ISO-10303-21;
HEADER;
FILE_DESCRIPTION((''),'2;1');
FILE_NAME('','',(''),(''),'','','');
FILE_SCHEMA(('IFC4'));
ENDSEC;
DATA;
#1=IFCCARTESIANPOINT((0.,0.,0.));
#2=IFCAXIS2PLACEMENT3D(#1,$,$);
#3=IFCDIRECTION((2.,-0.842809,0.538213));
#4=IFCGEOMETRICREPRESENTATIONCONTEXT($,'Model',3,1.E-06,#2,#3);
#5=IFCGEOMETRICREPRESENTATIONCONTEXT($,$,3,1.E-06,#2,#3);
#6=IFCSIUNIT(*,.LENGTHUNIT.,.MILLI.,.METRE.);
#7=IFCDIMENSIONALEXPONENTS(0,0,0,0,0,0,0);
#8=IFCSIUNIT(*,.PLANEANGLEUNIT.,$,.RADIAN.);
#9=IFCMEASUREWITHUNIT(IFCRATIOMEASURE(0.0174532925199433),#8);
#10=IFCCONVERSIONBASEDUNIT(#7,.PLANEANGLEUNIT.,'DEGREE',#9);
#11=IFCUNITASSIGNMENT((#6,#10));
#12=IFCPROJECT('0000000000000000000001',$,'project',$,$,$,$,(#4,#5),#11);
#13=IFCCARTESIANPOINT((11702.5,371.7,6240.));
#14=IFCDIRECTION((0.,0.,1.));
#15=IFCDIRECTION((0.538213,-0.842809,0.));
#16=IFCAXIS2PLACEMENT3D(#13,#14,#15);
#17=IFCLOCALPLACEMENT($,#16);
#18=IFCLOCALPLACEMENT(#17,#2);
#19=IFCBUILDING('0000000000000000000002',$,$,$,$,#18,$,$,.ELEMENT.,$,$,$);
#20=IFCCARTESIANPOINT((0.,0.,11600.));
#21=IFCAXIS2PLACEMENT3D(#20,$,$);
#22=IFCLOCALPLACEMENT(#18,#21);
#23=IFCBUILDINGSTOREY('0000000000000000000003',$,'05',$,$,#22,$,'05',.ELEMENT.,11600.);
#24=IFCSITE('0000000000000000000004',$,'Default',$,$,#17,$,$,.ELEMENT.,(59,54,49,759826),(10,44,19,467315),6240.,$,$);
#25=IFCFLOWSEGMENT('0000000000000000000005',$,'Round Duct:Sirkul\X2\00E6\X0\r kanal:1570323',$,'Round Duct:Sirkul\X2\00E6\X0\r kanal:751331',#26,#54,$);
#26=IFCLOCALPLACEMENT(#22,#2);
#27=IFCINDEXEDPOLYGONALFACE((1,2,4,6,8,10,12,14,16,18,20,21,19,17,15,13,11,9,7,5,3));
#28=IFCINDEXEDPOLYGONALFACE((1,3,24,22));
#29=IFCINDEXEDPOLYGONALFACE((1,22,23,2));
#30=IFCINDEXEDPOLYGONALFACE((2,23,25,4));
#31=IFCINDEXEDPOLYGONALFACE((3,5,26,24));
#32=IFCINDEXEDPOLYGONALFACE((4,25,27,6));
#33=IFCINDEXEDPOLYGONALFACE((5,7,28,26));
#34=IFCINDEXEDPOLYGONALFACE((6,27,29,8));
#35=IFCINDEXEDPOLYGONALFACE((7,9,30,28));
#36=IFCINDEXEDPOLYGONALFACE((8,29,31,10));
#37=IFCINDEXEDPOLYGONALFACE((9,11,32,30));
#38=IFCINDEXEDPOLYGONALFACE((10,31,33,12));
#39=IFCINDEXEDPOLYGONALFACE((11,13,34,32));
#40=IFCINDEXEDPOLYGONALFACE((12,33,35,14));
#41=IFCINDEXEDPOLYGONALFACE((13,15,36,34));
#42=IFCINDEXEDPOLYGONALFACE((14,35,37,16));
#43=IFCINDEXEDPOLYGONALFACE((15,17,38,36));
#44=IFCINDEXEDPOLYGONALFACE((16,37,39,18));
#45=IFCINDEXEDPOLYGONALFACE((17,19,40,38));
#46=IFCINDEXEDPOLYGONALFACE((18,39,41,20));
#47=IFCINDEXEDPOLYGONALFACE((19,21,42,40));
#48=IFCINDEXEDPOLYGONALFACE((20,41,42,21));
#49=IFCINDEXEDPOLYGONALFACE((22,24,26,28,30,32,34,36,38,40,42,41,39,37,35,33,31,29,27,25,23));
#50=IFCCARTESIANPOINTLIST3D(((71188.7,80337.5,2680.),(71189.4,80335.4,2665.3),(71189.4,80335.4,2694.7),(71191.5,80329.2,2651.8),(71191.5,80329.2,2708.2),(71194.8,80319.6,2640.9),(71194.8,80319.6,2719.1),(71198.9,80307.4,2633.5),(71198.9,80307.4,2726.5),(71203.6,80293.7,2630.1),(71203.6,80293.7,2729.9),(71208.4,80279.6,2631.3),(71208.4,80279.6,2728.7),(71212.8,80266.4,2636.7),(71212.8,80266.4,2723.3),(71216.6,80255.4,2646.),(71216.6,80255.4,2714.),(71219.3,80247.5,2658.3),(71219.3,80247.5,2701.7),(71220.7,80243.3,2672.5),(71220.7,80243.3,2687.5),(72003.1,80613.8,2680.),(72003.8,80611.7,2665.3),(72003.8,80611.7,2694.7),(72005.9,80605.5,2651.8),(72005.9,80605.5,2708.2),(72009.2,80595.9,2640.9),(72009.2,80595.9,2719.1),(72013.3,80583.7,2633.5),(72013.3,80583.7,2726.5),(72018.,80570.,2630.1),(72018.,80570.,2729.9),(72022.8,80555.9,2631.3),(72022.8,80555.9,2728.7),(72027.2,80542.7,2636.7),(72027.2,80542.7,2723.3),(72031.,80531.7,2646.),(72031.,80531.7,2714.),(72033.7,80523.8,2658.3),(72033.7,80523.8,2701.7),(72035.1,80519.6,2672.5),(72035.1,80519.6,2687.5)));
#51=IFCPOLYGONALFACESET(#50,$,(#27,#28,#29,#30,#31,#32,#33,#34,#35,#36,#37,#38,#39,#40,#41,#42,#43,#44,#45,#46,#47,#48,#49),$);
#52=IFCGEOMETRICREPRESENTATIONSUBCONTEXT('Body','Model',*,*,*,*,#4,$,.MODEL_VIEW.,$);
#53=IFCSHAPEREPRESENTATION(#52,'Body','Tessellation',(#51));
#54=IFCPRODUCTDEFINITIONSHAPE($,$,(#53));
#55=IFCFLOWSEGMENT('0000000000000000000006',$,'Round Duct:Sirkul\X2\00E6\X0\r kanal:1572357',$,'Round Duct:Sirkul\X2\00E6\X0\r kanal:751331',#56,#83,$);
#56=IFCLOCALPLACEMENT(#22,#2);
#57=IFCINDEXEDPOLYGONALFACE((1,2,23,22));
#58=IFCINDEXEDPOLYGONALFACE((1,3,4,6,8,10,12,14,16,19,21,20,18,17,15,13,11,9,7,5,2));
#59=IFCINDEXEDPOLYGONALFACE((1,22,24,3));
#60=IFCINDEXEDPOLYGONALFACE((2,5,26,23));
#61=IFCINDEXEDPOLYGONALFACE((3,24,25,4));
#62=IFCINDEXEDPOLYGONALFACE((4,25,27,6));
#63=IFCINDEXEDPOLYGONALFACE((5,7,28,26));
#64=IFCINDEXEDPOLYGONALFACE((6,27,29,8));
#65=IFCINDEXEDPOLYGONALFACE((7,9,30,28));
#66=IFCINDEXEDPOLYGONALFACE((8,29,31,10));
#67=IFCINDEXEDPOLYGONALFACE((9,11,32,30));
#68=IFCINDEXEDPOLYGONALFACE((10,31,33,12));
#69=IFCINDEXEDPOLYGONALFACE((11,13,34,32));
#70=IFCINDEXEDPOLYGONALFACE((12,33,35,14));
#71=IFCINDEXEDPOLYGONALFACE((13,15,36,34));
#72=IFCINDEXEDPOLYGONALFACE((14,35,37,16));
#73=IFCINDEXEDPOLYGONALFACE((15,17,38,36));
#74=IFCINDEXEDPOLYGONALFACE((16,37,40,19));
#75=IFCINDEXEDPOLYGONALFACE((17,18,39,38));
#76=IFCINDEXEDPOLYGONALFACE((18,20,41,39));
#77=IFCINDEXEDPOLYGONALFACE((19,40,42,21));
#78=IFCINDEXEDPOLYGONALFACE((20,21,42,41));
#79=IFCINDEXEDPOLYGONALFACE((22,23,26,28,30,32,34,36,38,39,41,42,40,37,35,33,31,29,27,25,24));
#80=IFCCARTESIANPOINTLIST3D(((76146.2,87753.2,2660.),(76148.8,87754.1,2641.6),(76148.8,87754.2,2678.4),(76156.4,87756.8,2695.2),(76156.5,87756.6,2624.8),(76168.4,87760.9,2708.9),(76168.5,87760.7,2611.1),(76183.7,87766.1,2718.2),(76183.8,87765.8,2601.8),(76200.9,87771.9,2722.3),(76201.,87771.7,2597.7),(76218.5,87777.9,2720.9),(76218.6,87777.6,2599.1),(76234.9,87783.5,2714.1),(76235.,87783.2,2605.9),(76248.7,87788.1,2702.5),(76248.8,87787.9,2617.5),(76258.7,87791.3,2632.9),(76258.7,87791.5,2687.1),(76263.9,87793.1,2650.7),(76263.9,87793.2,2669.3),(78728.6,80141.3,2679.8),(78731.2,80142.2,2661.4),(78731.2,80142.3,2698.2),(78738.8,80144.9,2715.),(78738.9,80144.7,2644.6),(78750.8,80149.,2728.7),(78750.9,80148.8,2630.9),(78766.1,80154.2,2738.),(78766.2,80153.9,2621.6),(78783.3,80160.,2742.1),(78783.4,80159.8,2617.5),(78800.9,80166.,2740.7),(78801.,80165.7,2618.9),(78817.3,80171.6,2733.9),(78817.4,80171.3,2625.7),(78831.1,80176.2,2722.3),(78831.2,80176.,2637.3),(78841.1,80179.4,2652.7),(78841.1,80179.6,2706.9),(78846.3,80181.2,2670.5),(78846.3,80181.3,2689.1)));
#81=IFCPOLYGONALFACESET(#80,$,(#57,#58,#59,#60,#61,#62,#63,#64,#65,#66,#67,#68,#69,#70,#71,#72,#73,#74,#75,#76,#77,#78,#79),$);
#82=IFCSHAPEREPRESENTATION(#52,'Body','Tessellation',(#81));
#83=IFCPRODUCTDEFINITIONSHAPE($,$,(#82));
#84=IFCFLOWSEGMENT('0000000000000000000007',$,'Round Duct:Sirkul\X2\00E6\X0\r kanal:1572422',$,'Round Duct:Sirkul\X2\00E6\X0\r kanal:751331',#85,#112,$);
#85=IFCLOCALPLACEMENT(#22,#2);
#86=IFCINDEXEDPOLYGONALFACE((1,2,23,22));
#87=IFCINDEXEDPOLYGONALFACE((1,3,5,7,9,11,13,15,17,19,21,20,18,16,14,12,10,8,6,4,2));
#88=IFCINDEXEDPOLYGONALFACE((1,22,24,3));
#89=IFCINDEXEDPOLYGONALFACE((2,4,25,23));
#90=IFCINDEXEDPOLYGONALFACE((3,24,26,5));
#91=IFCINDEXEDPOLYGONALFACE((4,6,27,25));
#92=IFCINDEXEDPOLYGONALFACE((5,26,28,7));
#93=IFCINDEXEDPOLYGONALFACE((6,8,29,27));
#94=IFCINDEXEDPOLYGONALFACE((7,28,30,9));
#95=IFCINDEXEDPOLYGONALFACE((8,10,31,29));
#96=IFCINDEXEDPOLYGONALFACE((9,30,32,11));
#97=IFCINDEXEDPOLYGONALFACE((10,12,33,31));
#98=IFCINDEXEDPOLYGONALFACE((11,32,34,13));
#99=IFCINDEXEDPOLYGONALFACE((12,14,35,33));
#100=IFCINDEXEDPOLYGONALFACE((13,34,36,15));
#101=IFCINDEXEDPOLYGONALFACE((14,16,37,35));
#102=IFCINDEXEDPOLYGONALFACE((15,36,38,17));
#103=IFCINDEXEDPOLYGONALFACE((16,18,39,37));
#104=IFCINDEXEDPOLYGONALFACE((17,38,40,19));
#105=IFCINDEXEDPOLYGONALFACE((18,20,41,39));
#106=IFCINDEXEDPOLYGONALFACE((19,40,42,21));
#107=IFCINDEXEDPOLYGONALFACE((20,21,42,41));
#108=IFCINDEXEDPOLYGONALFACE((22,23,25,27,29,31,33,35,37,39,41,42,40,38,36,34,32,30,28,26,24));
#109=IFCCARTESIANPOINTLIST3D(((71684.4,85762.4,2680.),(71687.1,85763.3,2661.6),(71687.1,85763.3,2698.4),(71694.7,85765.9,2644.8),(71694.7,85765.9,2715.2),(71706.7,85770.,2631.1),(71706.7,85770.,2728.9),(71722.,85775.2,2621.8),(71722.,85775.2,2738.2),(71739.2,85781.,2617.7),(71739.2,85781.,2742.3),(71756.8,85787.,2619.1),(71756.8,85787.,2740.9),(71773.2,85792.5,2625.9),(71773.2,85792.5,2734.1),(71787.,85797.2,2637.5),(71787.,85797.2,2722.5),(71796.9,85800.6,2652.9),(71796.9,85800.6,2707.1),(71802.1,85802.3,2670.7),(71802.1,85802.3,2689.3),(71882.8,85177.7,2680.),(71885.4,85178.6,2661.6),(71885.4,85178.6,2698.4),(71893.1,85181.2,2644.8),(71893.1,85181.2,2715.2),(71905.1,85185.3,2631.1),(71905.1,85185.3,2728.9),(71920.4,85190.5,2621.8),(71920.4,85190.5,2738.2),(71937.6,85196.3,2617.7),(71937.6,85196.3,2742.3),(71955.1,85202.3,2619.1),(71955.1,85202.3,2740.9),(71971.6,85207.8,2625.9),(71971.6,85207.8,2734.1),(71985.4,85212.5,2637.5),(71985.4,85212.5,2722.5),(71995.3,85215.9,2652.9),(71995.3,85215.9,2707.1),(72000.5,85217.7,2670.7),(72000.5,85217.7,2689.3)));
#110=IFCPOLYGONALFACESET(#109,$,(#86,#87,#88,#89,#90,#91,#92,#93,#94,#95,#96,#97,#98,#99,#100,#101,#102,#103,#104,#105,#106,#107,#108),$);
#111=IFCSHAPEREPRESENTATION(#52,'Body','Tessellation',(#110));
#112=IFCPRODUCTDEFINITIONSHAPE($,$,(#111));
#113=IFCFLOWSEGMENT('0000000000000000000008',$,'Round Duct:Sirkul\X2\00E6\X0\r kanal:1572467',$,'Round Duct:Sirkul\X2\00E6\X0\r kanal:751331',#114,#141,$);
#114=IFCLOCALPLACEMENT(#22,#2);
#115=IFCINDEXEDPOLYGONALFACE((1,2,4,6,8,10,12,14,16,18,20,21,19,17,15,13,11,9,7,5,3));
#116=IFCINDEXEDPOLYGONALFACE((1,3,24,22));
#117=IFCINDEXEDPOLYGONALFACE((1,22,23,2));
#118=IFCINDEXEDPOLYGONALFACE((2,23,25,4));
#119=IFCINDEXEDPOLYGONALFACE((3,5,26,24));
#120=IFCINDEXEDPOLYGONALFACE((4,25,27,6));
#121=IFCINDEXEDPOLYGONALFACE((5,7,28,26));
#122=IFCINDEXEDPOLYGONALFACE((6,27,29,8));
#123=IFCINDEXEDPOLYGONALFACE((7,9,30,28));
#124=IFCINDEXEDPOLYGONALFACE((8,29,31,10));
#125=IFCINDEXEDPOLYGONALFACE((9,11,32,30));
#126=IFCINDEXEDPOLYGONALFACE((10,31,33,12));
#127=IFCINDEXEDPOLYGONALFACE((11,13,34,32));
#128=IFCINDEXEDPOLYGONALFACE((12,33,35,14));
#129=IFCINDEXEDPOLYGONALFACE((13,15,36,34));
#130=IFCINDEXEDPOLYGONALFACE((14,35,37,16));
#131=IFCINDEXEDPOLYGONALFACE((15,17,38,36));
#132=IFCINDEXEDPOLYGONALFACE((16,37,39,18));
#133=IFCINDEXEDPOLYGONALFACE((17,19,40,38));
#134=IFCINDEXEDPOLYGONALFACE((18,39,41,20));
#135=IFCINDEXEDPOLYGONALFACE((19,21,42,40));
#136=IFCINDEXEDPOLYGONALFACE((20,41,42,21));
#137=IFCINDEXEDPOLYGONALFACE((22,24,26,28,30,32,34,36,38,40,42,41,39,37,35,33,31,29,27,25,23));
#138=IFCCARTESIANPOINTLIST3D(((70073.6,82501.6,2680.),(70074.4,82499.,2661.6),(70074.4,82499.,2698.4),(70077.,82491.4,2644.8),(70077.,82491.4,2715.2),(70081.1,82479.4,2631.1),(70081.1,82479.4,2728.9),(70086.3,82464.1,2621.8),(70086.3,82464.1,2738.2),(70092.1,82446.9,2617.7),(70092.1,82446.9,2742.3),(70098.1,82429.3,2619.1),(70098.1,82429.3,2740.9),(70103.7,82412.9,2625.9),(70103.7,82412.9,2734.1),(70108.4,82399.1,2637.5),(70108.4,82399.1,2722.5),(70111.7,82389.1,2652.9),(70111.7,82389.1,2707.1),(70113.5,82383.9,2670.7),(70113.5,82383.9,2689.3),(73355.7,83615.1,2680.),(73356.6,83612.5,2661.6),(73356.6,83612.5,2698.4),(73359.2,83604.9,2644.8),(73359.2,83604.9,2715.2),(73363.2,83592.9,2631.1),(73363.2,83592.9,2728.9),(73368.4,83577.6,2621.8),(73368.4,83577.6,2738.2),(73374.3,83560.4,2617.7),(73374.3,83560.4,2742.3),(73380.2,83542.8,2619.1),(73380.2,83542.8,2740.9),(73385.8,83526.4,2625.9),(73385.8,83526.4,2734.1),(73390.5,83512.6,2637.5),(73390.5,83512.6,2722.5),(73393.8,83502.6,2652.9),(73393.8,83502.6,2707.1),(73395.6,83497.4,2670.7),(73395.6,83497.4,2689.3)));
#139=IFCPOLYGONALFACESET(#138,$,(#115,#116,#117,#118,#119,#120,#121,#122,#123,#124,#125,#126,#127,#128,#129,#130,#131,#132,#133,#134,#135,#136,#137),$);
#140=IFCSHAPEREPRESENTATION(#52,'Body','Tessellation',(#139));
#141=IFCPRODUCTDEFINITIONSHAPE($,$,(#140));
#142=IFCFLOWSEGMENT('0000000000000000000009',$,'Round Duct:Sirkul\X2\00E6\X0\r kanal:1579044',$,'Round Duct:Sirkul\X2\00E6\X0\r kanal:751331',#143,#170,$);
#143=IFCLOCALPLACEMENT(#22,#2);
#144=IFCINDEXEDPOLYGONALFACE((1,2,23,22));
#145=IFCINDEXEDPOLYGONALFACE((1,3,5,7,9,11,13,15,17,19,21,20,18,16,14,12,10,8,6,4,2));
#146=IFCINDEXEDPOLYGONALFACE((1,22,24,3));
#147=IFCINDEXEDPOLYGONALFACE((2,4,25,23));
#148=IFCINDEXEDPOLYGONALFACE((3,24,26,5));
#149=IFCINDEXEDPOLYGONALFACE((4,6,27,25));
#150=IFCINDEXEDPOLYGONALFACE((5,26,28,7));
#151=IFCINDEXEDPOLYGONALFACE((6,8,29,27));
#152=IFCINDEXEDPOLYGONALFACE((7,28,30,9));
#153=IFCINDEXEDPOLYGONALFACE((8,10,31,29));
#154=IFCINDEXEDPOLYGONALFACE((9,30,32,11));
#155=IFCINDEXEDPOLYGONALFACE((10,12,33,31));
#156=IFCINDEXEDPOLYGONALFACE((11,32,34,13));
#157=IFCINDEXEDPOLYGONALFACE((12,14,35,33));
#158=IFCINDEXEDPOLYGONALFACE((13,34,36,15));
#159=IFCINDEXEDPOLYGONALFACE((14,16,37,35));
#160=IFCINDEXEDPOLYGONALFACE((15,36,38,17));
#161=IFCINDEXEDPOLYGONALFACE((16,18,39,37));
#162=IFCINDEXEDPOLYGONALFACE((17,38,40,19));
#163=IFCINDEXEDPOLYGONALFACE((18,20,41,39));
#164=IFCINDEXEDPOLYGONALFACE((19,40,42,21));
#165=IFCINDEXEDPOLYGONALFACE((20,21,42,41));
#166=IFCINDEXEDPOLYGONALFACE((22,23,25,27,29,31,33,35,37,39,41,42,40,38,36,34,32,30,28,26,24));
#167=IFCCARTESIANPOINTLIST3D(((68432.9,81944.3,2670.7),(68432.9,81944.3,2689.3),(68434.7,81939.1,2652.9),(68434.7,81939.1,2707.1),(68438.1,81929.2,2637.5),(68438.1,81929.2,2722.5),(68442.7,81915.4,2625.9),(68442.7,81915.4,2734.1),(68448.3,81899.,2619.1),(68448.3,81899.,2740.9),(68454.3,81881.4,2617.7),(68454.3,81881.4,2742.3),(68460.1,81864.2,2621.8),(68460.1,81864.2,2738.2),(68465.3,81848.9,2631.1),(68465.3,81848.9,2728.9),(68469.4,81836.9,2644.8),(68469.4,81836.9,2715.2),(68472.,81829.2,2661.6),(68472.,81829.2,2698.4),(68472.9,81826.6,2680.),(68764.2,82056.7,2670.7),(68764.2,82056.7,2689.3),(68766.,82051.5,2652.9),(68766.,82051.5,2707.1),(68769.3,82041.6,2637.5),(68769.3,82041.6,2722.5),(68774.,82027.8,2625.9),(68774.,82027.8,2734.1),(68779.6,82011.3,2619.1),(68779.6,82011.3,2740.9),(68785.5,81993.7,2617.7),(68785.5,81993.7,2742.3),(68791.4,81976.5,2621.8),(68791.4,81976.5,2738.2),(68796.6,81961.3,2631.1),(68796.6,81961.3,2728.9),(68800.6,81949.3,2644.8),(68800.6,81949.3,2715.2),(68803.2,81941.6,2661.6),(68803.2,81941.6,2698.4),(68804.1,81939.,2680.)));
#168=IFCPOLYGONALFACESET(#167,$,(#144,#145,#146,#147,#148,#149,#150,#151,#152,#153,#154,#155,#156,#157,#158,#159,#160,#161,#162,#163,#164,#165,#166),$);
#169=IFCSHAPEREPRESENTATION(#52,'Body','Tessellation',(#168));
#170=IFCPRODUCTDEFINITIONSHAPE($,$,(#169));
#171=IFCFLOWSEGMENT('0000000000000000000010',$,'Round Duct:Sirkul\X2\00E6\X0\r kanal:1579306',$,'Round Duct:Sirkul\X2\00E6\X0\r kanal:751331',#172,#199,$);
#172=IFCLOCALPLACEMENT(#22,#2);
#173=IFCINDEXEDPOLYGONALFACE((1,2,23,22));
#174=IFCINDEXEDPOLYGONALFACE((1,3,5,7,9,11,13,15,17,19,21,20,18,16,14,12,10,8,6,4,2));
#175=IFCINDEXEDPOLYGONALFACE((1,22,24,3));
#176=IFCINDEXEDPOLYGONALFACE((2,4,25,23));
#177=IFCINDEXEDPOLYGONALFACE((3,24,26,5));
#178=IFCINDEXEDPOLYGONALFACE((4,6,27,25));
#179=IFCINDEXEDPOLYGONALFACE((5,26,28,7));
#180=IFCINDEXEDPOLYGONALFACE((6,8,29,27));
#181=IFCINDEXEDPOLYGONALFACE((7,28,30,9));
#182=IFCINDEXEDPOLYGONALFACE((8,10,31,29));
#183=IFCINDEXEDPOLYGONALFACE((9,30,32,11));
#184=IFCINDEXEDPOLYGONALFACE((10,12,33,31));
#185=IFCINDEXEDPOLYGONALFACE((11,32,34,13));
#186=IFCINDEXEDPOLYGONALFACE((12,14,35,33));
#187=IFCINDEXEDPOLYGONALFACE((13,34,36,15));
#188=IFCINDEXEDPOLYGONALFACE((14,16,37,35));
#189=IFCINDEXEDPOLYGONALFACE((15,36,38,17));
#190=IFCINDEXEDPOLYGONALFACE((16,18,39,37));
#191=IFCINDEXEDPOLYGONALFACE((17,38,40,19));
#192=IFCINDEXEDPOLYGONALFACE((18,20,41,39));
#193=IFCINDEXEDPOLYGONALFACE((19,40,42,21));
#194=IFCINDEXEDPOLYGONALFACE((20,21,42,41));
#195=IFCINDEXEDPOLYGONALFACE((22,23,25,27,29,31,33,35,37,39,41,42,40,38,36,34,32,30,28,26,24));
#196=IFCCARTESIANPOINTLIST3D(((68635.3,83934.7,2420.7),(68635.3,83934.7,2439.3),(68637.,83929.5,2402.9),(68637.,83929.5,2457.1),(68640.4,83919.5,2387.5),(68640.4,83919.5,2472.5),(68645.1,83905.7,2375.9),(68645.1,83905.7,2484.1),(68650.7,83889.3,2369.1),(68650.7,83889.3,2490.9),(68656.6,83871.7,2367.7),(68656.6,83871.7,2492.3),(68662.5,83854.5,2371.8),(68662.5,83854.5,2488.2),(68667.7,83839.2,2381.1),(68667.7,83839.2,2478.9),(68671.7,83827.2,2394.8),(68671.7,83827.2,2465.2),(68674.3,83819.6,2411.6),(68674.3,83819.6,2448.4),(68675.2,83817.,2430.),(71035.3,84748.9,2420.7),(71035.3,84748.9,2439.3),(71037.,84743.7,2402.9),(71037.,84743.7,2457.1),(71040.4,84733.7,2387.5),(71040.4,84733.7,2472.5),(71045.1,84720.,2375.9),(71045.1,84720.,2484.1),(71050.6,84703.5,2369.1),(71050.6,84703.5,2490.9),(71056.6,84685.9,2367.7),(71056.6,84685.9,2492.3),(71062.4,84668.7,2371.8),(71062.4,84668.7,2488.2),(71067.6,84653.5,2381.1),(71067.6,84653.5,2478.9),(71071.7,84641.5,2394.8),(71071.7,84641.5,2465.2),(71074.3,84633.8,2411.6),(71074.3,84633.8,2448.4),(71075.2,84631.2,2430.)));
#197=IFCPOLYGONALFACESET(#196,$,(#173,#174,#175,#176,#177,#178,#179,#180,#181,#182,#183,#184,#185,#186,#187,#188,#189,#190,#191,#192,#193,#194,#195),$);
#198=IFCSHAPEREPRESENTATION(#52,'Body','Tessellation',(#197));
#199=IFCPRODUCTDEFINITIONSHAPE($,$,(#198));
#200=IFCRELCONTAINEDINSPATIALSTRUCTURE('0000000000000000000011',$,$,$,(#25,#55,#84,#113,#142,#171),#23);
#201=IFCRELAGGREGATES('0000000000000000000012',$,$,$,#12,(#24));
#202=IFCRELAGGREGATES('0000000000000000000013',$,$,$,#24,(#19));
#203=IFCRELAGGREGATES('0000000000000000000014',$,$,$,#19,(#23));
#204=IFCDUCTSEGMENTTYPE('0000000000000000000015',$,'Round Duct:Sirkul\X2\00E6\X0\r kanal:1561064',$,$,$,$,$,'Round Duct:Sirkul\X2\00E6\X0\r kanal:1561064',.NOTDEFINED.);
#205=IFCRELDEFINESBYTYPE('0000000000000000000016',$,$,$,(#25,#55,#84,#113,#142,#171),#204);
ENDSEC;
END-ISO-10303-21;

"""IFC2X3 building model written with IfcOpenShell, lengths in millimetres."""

from ifc_helpers import new_model, entity, si_unit, converted_unit, direction, frame, frame_2d, origin, origin_2d_with_axis, place, context, subcontext, project, spatial, circle, extrude, type_object, element, save


model = new_model("IFC2X3")

# Units and contexts
model_context = context("Model", 3, precision=1e-06, world=origin(), true_north=direction((2.0, -0.842809, 0.538213)))
context_of_model = context(None, 3, precision=1e-06, world=origin(), true_north=direction((2.0, -0.842809, 0.538213)))
body_context = subcontext(model_context, "Body", "Model", "MODEL_VIEW")
ifc_project = project(units=[si_unit("LENGTHUNIT", "METRE", prefix="MILLI"), converted_unit("PLANEANGLEUNIT", "DEGREE", entity("IfcRatioMeasure", 0.0174532925199433), si_unit("PLANEANGLEUNIT", "RADIAN"), dimensions=[0, 0, 0, 0, 0, 0, 0])], contexts=[model_context, context_of_model])

# Site, building, storey
site_placement = place(None, frame((11702.5, 371.7, 6240.0), z_axis=(0.0, 0.0, 1.0), x_axis=(0.538213, -0.842809, 0.0)))
site = spatial("IfcSite", under=ifc_project, at=site_placement, Name="Default", CompositionType="ELEMENT", RefLatitude=(59, 54, 49, 759826), RefLongitude=(10, 44, 19, 467315), RefElevation=6240.0)
building_placement = place(site_placement, origin())
building = spatial("IfcBuilding", under=site, at=building_placement, CompositionType="ELEMENT")
storey_placement = place(building_placement, frame((0.0, 0.0, 11600.0)))
storey = spatial("IfcBuildingStorey", under=building, at=storey_placement, Name="05", LongName="05", CompositionType="ELEMENT", Elevation=11600.0)

# Flow segments
duct_segment_type = type_object("IfcDuctSegmentType", Name="Round Duct:Sirkulær kanal:1561064", ElementType="Round Duct:Sirkulær kanal:1561064", PredefinedType="NOTDEFINED")
flow_segment_1_placement = place(storey_placement, origin())
element("IfcFlowSegment", 1, at=flow_segment_1_placement, inside=storey, type_object=duct_segment_type, Name="Round Duct:Sirkulær kanal:1570323", ObjectType="Round Duct:Sirkulær kanal:751331", context=body_context, shape_type="SweptSolid", body=[
    extrude(circle(Radius=50.0, at=origin_2d_with_axis()), frame((71204.8, 80290.1, 2680.0), z_axis=(0.946986, 0.321274, 0.0), x_axis=(-0.321274, 0.946986, 0.0)), (0.0, 0.0, 1.0), 860.0),
])
flow_segment_2_placement = place(storey_placement, origin())
element("IfcFlowSegment", 2, at=flow_segment_2_placement, inside=storey, type_object=duct_segment_type, Name="Round Duct:Sirkulær kanal:1572357", ObjectType="Round Duct:Sirkulær kanal:751331", context=body_context, shape_type="SweptSolid", body=[
    extrude(circle(Radius=62.5, at=origin_2d_with_axis()), frame((78787.8, 80161.4, 2679.8), z_axis=(-0.321273, 0.946983, -0.002464), x_axis=(-0.946986, -0.321274, 0.0)), (0.0, 0.0, 1.0), 8038.0),
])
flow_segment_3_placement = place(storey_placement, origin())
element("IfcFlowSegment", 3, at=flow_segment_3_placement, inside=storey, type_object=duct_segment_type, Name="Round Duct:Sirkulær kanal:1572422", ObjectType="Round Duct:Sirkulær kanal:751331", context=body_context, shape_type="SweptSolid", body=[
    extrude(circle(Radius=62.5, at=origin_2d_with_axis()), frame((71942.0, 85197.8, 2680.0), z_axis=(-0.321274, 0.946986, 0.0), x_axis=(-0.946986, -0.321274, 0.0)), (0.0, 0.0, 1.0), 617.4),
])
flow_segment_4_placement = place(storey_placement, origin())
element("IfcFlowSegment", 4, at=flow_segment_4_placement, inside=storey, type_object=duct_segment_type, Name="Round Duct:Sirkulær kanal:1572467", ObjectType="Round Duct:Sirkulær kanal:751331", context=body_context, shape_type="SweptSolid", body=[
    extrude(circle(Radius=62.5, at=origin_2d_with_axis()), frame((70093.6, 82442.5, 2680.0), z_axis=(0.946986, 0.321274, 0.0), x_axis=(-0.321274, 0.946986, 0.0)), (0.0, 0.0, 1.0), 3465.9),
])
flow_segment_5_placement = place(storey_placement, origin())
element("IfcFlowSegment", 5, at=flow_segment_5_placement, inside=storey, type_object=duct_segment_type, Name="Round Duct:Sirkulær kanal:1579044", ObjectType="Round Duct:Sirkulær kanal:751331", context=body_context, shape_type="SweptSolid", body=[
    extrude(circle(Radius=62.5, at=frame_2d((0.0, 0.0), x_axis=(1.0, 0.0))), frame((68452.8, 81885.8, 2680.0), z_axis=(0.946986, 0.321274, 0.0), x_axis=(0.321274, -0.946986, 0.0)), (0.0, 0.0, 1.0), 349.8),
])
flow_segment_6_placement = place(storey_placement, origin())
element("IfcFlowSegment", 6, at=flow_segment_6_placement, inside=storey, type_object=duct_segment_type, Name="Round Duct:Sirkulær kanal:1579306", ObjectType="Round Duct:Sirkulær kanal:751331", context=body_context, shape_type="SweptSolid", body=[
    extrude(circle(Radius=62.5, at=origin_2d_with_axis()), frame((68655.1, 83876.1, 2430.0), z_axis=(0.946986, 0.321274, 0.0), x_axis=(0.321274, -0.946986, 0.0)), (0.0, 0.0, 1.0), 2534.3),
])

save(model, "model.ifc")
